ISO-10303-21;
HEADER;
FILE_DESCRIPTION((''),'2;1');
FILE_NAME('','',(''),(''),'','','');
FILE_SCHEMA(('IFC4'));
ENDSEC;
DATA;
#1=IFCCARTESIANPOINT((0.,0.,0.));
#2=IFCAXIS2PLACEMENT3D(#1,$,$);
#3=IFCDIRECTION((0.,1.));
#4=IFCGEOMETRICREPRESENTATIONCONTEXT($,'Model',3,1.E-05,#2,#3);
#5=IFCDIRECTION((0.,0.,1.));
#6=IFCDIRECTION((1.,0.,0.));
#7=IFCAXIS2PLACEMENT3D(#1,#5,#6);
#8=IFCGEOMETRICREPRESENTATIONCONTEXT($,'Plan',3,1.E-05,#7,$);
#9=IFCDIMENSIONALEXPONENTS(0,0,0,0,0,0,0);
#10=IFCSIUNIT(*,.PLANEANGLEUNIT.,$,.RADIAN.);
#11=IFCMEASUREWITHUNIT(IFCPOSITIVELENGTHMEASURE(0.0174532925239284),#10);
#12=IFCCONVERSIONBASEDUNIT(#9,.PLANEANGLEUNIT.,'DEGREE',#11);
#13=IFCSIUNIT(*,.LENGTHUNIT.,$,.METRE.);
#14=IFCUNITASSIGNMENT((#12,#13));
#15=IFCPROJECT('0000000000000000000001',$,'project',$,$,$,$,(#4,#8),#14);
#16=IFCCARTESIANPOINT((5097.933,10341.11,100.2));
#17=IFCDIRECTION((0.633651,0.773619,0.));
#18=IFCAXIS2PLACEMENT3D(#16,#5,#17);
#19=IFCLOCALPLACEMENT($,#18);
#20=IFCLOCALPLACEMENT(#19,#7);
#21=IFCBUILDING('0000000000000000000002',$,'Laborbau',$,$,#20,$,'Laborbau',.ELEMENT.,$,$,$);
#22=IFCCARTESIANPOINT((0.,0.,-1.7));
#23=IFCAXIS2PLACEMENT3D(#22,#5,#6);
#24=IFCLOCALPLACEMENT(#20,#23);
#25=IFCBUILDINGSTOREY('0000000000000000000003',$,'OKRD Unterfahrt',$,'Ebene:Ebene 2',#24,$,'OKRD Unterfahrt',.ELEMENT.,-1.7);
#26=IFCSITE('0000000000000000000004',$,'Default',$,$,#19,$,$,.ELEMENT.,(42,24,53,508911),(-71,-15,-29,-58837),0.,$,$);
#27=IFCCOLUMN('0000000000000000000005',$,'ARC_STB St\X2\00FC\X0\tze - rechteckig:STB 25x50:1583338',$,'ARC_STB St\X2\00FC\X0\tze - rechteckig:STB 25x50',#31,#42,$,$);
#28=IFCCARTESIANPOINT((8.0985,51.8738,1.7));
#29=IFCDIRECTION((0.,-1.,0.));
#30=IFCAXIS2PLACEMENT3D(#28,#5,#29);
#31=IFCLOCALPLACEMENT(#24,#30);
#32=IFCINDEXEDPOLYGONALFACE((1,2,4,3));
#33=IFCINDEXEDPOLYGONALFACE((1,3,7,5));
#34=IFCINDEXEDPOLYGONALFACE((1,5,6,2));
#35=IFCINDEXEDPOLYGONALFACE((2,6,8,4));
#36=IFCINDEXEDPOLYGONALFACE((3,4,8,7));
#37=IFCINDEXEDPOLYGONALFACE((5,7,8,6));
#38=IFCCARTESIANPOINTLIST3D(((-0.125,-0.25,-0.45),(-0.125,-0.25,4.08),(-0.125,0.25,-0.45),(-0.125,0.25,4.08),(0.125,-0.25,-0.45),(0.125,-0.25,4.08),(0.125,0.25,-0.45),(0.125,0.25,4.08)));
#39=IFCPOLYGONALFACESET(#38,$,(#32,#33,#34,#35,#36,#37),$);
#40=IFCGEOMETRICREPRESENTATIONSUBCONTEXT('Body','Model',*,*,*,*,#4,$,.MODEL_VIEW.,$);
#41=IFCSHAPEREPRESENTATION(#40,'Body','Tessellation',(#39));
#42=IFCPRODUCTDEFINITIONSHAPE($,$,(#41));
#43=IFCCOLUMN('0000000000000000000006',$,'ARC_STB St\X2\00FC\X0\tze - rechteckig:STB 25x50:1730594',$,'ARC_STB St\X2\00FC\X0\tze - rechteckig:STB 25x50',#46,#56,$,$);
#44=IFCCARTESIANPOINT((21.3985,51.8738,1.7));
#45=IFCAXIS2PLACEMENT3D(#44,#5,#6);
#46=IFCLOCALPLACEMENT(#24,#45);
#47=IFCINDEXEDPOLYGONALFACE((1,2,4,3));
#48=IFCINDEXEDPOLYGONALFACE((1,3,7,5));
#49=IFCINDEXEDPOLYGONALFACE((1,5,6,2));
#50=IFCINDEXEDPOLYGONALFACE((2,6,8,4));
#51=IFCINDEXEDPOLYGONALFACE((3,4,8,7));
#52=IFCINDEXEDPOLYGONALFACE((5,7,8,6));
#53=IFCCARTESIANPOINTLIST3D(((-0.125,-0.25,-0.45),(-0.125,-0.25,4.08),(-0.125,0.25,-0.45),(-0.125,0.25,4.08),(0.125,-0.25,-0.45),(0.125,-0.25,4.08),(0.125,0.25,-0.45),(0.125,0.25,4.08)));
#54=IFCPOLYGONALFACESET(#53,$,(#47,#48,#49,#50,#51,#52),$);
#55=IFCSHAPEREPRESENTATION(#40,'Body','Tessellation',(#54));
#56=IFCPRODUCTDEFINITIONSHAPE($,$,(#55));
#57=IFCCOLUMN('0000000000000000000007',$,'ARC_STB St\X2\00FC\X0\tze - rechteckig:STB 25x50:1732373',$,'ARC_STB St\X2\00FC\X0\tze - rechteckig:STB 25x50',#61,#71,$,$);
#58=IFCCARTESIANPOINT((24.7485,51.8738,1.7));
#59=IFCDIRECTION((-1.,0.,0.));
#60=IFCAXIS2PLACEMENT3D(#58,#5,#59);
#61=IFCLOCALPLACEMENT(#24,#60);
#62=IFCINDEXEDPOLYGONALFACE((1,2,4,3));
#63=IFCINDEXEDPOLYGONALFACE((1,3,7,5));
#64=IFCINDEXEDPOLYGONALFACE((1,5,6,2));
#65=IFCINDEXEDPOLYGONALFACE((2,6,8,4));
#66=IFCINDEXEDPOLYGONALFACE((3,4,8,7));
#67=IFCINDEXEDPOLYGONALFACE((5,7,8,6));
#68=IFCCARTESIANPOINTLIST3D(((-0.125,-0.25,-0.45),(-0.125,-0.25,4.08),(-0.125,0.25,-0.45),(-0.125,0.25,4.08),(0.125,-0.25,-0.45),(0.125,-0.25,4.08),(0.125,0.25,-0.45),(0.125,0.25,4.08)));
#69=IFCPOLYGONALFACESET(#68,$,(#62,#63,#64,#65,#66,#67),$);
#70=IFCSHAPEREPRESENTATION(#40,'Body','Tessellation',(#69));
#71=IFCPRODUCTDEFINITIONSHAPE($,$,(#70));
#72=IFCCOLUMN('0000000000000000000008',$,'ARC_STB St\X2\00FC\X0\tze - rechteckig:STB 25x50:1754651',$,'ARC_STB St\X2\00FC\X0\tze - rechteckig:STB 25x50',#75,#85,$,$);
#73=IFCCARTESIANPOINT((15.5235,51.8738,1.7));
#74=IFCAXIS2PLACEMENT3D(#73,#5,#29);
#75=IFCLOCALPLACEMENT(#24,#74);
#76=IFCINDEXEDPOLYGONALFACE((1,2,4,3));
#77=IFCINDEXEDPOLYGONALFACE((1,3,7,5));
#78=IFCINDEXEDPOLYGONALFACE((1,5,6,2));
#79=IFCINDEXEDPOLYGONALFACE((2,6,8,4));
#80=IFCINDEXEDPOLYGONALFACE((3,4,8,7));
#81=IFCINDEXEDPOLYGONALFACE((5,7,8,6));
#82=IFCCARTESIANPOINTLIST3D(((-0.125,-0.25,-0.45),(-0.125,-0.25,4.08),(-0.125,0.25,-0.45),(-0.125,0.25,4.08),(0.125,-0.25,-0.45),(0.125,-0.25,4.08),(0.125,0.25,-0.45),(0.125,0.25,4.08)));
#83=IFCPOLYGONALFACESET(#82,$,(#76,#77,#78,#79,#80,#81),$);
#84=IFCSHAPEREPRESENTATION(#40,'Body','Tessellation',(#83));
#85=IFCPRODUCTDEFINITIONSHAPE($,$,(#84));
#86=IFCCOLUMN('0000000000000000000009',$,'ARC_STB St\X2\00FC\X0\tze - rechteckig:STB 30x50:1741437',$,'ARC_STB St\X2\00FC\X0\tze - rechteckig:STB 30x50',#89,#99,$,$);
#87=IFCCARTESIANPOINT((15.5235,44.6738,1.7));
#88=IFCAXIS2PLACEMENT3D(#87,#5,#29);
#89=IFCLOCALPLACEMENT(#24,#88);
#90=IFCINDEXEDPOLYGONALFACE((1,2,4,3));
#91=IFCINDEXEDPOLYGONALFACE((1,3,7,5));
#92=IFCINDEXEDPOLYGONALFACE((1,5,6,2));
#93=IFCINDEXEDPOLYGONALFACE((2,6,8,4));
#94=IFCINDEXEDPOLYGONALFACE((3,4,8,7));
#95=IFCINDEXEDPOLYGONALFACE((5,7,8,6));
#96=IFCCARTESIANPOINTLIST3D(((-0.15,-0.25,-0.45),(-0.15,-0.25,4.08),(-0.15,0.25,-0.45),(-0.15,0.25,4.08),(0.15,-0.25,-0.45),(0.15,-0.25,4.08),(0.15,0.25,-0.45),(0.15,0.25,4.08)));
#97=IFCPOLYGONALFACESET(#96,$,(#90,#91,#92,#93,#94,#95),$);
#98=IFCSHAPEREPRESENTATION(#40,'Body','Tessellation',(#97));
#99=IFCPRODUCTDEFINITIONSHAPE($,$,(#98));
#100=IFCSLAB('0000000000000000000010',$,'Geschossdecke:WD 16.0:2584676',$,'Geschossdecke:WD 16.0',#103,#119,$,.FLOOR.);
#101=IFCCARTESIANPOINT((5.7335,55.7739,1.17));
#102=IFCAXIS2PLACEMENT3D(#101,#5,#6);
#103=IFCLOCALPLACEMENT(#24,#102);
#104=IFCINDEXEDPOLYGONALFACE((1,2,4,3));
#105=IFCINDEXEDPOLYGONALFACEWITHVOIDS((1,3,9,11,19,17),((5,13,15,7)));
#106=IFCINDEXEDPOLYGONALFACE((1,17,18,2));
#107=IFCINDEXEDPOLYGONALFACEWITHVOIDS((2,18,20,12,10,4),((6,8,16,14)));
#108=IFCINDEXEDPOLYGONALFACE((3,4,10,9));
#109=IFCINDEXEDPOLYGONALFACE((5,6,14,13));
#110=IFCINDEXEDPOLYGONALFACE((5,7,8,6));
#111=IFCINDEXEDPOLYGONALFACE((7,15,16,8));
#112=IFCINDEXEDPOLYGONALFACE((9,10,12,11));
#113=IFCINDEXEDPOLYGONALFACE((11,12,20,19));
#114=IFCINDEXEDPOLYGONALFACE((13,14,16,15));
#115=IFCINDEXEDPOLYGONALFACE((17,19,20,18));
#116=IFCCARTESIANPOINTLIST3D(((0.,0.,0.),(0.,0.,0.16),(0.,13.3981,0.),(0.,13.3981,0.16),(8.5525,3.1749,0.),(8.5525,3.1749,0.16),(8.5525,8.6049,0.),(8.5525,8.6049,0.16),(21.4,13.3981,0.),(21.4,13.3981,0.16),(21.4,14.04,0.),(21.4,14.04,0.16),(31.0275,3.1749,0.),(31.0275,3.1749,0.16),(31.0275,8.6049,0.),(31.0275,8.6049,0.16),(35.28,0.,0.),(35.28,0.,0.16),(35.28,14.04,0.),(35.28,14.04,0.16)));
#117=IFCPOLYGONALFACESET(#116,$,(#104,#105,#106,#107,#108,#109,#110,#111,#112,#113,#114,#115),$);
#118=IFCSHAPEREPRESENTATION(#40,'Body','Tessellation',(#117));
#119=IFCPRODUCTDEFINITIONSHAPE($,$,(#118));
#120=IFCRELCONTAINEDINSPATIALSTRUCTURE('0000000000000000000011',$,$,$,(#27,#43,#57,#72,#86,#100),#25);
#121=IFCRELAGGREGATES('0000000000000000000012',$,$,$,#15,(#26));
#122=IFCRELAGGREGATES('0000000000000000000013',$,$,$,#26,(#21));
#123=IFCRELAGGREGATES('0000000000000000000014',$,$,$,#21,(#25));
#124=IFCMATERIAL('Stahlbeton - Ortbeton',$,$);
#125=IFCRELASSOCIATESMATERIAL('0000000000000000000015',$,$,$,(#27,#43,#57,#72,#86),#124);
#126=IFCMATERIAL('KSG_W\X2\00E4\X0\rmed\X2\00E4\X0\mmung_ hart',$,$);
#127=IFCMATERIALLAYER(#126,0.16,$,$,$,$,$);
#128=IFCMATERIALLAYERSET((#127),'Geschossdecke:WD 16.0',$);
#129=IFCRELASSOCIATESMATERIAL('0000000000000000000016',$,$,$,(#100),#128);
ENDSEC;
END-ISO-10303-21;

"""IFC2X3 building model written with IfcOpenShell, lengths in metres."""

from ifc_helpers import new_model, entity, si_unit, converted_unit, direction, frame, origin, origin_with_axes, origin_2d_with_axis, place, context, subcontext, project, spatial, polyline, rectangle, outline, extrude, source, transform, mapped, material, layer, layer_set, layer_usage, element, save


model = new_model("IFC2X3")

# Units and contexts
model_context = context("Model", 3, precision=1e-05, world=origin(), true_north=direction((0.0, 1.0)))
plan_context = context("Plan", 3, precision=1e-05, world=origin_with_axes())
body_context = subcontext(model_context, "Body", "Model", "MODEL_VIEW")
ifc_project = project(units=[converted_unit("PLANEANGLEUNIT", "DEGREE", entity("IfcPositiveLengthMeasure", 0.0174532925239284), si_unit("PLANEANGLEUNIT", "RADIAN"), dimensions=[0, 0, 0, 0, 0, 0, 0]), si_unit("LENGTHUNIT", "METRE")], contexts=[model_context, plan_context])

# Site, building, storey
site_placement = place(None, frame((5097.933, 10341.11, 100.2), z_axis=(0.0, 0.0, 1.0), x_axis=(0.633651, 0.773619, 0.0)))
site = spatial("IfcSite", under=ifc_project, at=site_placement, Name="Default", CompositionType="ELEMENT", RefLatitude=(42, 24, 53, 508911), RefLongitude=(-71, -15, -29, -58837), RefElevation=0.0)
building_placement = place(site_placement, origin_with_axes())
building = spatial("IfcBuilding", under=site, at=building_placement, Name="Laborbau", LongName="Laborbau", CompositionType="ELEMENT")
storey_placement = place(building_placement, frame((0.0, 0.0, -1.7), z_axis=(0.0, 0.0, 1.0), x_axis=(1.0, 0.0, 0.0)))
storey = spatial("IfcBuildingStorey", under=building, at=storey_placement, Name="OKRD Unterfahrt", ObjectType="Ebene:Ebene 2", LongName="OKRD Unterfahrt", CompositionType="ELEMENT", Elevation=-1.7)

# Columns
ifc_material_1 = material(Name="Stahlbeton - Ortbeton")
shared_shape_1 = source(origin(), body_context, "Body", "SweptSolid", [
    extrude(rectangle(XDim=0.5, YDim=0.25, at=origin_2d_with_axis()), frame((0.0, 0.0, -0.45), z_axis=(0.0, 0.0, 1.0), x_axis=(0.0, -1.0, 0.0)), (0.0, 0.0, 1.0), 4.53),
])
for number, where, z_axis, x_axis, name in (
    (1, (8.0985, 51.8738, 1.7), (0.0, 0.0, 1.0), (0.0, -1.0, 0.0), "ARC_STB Stütze - rechteckig:STB 25x50:1583338"),
    (2, (21.3985, 51.8738, 1.7), (0.0, 0.0, 1.0), (1.0, 0.0, 0.0), "ARC_STB Stütze - rechteckig:STB 25x50:1730594"),
    (3, (24.7485, 51.8738, 1.7), (0.0, 0.0, 1.0), (-1.0, 0.0, 0.0), "ARC_STB Stütze - rechteckig:STB 25x50:1732373"),
    (4, (15.5235, 51.8738, 1.7), (0.0, 0.0, 1.0), (0.0, -1.0, 0.0), "ARC_STB Stütze - rechteckig:STB 25x50:1754651"),
):
    element("IfcColumn", number, at=place(storey_placement, frame(where, z_axis=z_axis, x_axis=x_axis)), inside=storey, material=ifc_material_1, Name=name, ObjectType="ARC_STB Stütze - rechteckig:STB 25x50", context=body_context, shape_type="MappedRepresentation", body=[
        mapped(shared_shape_1, transform((0.0, 0.0, 0.0), scale=1.0)),
    ])
shared_shape_2 = source(origin(), body_context, "Body", "SweptSolid", [
    extrude(rectangle(XDim=0.5, YDim=0.3, at=origin_2d_with_axis()), frame((0.0, 0.0, -0.45), z_axis=(0.0, 0.0, 1.0), x_axis=(0.0, -1.0, 0.0)), (0.0, 0.0, 1.0), 4.53),
])
column_placement = place(storey_placement, frame((15.5235, 44.6738, 1.7), z_axis=(0.0, 0.0, 1.0), x_axis=(0.0, -1.0, 0.0)))
element("IfcColumn", 5, at=column_placement, inside=storey, material=ifc_material_1, Name="ARC_STB Stütze - rechteckig:STB 30x50:1741437", ObjectType="ARC_STB Stütze - rechteckig:STB 30x50", context=body_context, shape_type="MappedRepresentation", body=[
    mapped(shared_shape_2, transform((0.0, 0.0, 0.0), scale=1.0)),
])

# Slab, opening
ifc_material_2 = material(Name="KSG_Wärmedämmung_ hart")
ifc_layer_1 = layer(ifc_material_2, 0.16)
ifc_layer_set_1 = layer_set([ifc_layer_1], Name="Geschossdecke:WD 16.0")
ifc_layer_usage_1 = layer_usage(ifc_layer_set_1, "AXIS3", "POSITIVE", 0.0)
slab_1_placement = place(storey_placement, frame((5.7335, 55.7739, 1.17), z_axis=(0.0, 0.0, 1.0), x_axis=(1.0, 0.0, 0.0)))
slab_1 = element("IfcSlab", 6, at=slab_1_placement, inside=storey, material=ifc_layer_usage_1, Name="Geschossdecke:WD 16.0:2584676", ObjectType="Geschossdecke:WD 16.0", PredefinedType="FLOOR", context=body_context, shape_type="SweptSolid", body=[
    extrude(outline(polyline([(-3.76, 6.3781), (-3.76, 7.02), (-17.64, 7.02), (-17.64, -7.02), (17.64, -7.02), (17.64, 6.3781), (-3.76, 6.3781)])), frame((17.64, 7.02, 0.16), z_axis=(0.0, 0.0, -1.0), x_axis=(-1.0, 0.0, 0.0)), (0.0, 0.0, 1.0), 0.16),
])
opening_placement = place(slab_1_placement, frame((19.79, 5.8899, 0.16), z_axis=(0.0, 0.0, 1.0), x_axis=(1.0, 0.0, 0.0)))
element("IfcOpeningElement", 7, at=opening_placement, cuts=slab_1, ObjectType="Opening", context=body_context, shape_type="SweptSolid", body=[
    extrude(rectangle(XDim=5.43, YDim=22.475, at=origin_2d_with_axis()), frame((0.0, 0.0, 0.0), z_axis=(0.0, 0.0, -1.0), x_axis=(0.0, 1.0, 0.0)), (0.0, 0.0, 1.0), 0.16),
])

save(model, "model.ifc")
